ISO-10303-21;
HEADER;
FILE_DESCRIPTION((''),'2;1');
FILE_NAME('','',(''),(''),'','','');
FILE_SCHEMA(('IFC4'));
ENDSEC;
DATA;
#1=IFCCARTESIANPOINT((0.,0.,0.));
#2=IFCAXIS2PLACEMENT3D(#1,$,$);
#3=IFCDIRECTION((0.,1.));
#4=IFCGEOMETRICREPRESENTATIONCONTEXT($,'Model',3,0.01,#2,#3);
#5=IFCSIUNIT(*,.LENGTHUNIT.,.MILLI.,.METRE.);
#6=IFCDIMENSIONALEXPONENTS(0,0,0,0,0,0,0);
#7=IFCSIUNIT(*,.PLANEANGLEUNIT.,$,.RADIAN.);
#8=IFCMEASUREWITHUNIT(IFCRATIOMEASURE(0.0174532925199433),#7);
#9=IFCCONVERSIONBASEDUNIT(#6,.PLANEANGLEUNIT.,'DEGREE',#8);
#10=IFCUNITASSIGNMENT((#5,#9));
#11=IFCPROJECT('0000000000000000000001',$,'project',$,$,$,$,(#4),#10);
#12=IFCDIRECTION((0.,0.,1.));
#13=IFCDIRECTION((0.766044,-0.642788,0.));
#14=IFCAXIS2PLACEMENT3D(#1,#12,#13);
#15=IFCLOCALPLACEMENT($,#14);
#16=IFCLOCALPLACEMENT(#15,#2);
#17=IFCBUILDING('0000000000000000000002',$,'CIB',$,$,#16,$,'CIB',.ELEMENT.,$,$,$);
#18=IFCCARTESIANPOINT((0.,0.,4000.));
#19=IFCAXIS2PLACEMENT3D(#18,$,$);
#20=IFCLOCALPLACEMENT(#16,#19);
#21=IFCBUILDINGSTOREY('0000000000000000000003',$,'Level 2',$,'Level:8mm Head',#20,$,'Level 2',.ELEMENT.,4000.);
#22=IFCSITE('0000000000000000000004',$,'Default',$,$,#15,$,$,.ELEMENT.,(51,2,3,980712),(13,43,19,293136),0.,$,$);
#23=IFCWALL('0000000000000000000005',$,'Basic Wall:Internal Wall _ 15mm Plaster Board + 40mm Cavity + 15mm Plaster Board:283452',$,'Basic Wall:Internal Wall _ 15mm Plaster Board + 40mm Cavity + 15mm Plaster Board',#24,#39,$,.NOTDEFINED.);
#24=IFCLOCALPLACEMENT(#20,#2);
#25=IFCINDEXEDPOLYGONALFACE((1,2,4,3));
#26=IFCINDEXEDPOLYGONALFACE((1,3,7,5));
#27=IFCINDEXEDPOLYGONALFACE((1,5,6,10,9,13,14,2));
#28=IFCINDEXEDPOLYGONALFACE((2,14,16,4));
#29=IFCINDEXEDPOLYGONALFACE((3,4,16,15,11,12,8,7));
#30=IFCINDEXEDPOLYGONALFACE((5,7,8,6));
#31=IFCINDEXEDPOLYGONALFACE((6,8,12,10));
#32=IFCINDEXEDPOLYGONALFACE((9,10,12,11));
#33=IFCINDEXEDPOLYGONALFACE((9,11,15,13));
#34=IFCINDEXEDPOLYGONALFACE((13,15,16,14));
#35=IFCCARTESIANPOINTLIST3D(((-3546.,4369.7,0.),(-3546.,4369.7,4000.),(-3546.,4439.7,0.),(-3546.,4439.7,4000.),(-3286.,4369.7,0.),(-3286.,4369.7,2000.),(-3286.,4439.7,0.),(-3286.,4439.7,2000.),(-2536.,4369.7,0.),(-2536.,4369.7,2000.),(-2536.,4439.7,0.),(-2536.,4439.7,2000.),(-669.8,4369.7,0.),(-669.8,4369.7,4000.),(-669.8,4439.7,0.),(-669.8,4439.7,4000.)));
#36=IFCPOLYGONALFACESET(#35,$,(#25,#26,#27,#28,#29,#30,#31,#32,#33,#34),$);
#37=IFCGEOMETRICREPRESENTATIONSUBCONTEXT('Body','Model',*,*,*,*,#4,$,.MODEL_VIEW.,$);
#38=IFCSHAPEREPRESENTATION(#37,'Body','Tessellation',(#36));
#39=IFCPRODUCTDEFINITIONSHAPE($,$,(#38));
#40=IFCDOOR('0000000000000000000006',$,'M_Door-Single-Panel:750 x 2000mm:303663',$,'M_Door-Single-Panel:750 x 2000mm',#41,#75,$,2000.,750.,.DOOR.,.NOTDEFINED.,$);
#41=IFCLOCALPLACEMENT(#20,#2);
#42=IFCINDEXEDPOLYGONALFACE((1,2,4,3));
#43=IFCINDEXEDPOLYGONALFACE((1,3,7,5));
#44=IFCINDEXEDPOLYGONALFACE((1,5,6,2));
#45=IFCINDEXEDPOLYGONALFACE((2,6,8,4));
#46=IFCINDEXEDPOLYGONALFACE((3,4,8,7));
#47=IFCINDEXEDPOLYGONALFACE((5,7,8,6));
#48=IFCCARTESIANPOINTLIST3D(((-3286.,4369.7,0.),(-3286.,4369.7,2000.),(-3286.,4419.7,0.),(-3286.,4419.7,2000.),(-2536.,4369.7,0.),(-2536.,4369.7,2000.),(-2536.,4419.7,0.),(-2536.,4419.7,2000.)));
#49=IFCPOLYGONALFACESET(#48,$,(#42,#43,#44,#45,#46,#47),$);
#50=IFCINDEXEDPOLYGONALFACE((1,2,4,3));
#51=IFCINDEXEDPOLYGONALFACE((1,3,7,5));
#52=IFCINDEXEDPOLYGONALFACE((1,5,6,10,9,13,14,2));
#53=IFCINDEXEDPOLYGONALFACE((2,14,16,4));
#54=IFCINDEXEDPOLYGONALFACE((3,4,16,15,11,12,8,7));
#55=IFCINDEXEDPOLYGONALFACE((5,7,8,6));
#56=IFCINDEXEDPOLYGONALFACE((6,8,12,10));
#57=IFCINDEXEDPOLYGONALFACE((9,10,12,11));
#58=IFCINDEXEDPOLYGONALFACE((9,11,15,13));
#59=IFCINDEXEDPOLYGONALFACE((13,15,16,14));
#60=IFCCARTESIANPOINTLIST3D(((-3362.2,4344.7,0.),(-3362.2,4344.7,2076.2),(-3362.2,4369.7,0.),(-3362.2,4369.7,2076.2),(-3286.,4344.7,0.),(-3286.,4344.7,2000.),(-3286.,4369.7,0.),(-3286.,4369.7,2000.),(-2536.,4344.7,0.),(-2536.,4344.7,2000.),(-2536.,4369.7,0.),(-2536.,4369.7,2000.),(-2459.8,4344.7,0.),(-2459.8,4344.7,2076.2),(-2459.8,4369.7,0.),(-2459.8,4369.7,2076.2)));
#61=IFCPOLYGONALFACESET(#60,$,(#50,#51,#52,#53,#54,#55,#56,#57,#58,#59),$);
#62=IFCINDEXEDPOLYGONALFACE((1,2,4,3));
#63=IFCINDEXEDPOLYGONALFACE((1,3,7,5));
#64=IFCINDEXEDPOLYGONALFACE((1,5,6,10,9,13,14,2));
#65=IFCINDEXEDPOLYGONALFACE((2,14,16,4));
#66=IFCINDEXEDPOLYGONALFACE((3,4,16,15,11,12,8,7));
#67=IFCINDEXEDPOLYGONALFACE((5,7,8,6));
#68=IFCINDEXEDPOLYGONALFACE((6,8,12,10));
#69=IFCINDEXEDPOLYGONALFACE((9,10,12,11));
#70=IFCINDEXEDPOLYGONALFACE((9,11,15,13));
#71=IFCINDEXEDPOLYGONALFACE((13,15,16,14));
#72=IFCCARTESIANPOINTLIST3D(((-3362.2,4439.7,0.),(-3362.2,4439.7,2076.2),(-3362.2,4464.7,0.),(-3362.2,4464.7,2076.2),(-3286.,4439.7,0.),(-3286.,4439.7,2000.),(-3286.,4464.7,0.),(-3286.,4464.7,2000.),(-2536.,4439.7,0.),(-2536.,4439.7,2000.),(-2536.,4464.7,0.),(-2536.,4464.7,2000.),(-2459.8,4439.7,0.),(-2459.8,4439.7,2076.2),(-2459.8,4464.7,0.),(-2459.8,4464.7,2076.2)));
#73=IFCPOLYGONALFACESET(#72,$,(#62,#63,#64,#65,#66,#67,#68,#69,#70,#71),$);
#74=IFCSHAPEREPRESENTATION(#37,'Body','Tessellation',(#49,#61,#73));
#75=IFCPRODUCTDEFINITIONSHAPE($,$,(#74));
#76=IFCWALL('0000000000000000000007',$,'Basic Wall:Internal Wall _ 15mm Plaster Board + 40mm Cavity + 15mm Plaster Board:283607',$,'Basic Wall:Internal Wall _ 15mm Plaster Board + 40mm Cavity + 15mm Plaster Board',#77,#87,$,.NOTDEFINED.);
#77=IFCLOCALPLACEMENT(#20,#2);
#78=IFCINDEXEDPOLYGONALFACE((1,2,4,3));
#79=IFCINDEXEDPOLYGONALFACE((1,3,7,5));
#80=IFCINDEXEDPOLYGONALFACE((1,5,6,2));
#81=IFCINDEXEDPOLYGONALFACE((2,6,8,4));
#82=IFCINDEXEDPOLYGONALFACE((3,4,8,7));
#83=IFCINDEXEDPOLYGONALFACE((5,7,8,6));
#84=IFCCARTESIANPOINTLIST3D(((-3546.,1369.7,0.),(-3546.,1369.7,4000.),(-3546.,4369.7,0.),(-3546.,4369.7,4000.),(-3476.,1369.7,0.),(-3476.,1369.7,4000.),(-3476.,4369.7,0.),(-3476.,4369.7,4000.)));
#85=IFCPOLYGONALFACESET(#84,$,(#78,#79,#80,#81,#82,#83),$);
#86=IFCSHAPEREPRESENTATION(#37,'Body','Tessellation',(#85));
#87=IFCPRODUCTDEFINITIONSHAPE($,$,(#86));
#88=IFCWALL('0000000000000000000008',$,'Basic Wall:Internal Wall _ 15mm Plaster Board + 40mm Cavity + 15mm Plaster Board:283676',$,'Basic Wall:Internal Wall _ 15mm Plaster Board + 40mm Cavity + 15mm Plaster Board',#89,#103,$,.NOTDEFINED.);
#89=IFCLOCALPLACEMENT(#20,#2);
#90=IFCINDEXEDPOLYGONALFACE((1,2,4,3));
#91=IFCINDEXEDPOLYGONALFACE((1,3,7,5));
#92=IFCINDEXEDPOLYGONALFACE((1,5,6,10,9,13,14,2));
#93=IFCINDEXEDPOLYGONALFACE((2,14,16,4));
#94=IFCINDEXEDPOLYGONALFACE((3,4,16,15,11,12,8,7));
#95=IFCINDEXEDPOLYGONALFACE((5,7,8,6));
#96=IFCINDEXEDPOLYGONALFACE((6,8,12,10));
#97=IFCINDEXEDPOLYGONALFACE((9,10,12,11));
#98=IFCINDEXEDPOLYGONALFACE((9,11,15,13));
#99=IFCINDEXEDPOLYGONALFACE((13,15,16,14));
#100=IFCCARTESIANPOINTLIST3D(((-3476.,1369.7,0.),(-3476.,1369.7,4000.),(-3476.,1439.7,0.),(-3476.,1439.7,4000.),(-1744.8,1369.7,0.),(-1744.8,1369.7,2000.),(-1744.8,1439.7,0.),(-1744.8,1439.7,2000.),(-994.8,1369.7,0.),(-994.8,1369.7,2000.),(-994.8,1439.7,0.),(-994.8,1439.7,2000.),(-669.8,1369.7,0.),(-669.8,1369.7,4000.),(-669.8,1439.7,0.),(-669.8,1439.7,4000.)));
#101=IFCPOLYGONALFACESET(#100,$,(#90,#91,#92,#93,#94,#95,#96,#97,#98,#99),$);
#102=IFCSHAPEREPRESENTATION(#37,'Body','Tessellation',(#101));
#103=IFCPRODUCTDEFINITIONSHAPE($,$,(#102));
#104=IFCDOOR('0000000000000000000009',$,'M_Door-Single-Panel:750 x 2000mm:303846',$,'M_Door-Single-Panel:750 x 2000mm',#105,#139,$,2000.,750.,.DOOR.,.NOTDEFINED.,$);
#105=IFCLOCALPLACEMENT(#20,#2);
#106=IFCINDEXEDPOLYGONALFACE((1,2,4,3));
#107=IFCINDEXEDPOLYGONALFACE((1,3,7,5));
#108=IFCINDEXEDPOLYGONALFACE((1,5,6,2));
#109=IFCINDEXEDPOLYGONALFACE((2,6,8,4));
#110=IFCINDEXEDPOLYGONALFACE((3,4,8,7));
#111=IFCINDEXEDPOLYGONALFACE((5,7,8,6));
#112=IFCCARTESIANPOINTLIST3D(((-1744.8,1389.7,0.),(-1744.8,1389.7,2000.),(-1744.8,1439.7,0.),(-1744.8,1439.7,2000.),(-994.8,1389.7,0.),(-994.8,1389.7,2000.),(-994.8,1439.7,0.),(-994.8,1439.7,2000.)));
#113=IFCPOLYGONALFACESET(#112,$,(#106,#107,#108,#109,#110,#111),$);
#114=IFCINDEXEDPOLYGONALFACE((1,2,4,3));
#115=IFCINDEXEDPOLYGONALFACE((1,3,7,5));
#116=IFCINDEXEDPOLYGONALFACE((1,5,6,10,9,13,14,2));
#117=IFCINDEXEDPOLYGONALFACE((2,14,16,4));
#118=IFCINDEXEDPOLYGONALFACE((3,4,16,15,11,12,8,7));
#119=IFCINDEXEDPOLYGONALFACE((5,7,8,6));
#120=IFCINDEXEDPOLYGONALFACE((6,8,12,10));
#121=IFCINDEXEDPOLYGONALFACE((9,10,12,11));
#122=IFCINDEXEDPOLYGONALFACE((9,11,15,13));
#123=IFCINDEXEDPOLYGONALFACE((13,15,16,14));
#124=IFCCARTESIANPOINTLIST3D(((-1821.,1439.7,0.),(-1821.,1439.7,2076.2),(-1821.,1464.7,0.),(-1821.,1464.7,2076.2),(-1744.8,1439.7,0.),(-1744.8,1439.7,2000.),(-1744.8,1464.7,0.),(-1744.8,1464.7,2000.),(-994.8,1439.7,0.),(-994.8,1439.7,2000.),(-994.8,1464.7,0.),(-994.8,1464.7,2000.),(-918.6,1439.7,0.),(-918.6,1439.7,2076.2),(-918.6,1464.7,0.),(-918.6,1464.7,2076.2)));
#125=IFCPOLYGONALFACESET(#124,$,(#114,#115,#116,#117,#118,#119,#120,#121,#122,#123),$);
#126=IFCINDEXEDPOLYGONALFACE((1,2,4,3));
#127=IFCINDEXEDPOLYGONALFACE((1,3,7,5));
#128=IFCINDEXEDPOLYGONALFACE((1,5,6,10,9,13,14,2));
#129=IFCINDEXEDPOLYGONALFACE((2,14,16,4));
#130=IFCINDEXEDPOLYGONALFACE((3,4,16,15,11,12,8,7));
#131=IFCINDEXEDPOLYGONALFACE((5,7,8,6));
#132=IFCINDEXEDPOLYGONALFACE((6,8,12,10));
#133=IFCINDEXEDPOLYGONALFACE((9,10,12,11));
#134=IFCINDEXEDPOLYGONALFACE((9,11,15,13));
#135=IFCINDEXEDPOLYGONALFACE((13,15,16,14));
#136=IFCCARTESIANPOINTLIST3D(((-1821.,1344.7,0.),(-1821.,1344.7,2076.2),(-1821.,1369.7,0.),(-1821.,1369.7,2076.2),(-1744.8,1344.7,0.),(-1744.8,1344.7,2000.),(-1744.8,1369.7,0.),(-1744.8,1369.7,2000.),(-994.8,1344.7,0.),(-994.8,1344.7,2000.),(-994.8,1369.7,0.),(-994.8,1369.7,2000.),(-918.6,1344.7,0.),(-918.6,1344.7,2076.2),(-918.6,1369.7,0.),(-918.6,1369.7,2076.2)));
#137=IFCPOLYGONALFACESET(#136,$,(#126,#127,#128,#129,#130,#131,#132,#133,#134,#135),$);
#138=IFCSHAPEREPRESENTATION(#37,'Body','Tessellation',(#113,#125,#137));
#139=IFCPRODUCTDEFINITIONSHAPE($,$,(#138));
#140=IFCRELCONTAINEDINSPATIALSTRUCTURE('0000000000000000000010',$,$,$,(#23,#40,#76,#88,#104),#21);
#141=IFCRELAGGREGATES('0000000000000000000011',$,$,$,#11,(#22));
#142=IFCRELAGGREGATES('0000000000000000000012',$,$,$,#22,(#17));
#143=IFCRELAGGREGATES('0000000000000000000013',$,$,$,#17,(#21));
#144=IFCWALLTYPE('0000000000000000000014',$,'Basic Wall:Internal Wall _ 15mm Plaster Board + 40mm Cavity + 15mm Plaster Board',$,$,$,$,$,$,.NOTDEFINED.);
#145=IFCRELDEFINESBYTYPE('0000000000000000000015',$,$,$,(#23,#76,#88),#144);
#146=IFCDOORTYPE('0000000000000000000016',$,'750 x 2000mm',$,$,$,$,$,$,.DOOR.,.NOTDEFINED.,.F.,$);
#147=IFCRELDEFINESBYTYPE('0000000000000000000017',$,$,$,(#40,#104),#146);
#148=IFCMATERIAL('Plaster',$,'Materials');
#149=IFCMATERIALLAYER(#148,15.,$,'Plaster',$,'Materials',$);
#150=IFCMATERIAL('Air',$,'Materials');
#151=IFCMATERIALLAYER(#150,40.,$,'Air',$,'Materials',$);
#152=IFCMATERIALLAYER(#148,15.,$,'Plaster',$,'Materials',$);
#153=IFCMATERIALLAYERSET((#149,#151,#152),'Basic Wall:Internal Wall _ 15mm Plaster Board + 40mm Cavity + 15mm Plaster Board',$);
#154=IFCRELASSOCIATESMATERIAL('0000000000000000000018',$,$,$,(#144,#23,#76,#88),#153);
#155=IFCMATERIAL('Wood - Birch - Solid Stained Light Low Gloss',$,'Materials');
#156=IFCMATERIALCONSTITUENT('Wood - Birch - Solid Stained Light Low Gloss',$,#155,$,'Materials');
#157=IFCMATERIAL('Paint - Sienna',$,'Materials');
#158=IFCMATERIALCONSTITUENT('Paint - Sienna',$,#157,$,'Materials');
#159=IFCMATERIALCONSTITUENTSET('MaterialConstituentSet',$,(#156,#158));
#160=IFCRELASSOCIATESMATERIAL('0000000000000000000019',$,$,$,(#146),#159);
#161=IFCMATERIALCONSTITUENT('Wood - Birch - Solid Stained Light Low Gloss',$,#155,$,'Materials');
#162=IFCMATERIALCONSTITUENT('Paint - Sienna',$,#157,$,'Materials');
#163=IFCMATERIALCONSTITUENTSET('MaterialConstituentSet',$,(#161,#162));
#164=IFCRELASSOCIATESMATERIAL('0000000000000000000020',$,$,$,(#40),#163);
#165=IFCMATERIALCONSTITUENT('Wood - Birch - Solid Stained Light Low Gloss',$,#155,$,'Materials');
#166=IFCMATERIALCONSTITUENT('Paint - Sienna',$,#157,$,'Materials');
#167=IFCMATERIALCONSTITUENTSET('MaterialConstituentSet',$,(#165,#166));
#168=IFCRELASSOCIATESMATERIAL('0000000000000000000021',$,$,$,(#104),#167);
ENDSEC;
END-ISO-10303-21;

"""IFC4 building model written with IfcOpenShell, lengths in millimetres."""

from ifc_helpers import new_model, entity, si_unit, converted_unit, direction, frame, frame_2d, origin, origin_2d_with_axis, place, context, subcontext, project, spatial, polyline, rectangle, outline, extrude, source, transform, mapped, material, layer, layer_set, layer_usage, constituent, constituent_set, type_object, type_shapes, element, fill, save


model = new_model("IFC4")

# Units and contexts
model_context = context("Model", 3, precision=0.01, world=origin(), true_north=direction((0.0, 1.0)))
body_context = subcontext(model_context, "Body", "Model", "MODEL_VIEW")
ifc_project = project(units=[si_unit("LENGTHUNIT", "METRE", prefix="MILLI"), converted_unit("PLANEANGLEUNIT", "DEGREE", entity("IfcRatioMeasure", 0.0174532925199433), si_unit("PLANEANGLEUNIT", "RADIAN"), dimensions=[0, 0, 0, 0, 0, 0, 0])], contexts=[model_context])

# Site, building, storey
site_placement = place(None, frame((0.0, 0.0, 0.0), z_axis=(0.0, 0.0, 1.0), x_axis=(0.766044, -0.642788, 0.0)))
site = spatial("IfcSite", under=ifc_project, at=site_placement, Name="Default", CompositionType="ELEMENT", RefLatitude=(51, 2, 3, 980712), RefLongitude=(13, 43, 19, 293136), RefElevation=0.0)
building_placement = place(site_placement, origin())
building = spatial("IfcBuilding", under=site, at=building_placement, Name="CIB", LongName="CIB", CompositionType="ELEMENT")
storey_placement = place(building_placement, frame((0.0, 0.0, 4000.0)))
storey = spatial("IfcBuildingStorey", under=building, at=storey_placement, Name="Level 2", ObjectType="Level:8mm Head", LongName="Level 2", CompositionType="ELEMENT", Elevation=4000.0)

# Shared definitions
ifc_material_1 = material(Name="Plaster", Category="Materials")

# Wall, opening, door
ifc_layer_1 = layer(ifc_material_1, 15.0, Name="Plaster", Category="Materials")
ifc_material_2 = material(Name="Air", Category="Materials")
ifc_layer_2 = layer(ifc_material_2, 40.0, Name="Air", Category="Materials")
ifc_layer_3 = layer(ifc_material_1, 15.0, Name="Plaster", Category="Materials")
ifc_layer_set_1 = layer_set([ifc_layer_1, ifc_layer_2, ifc_layer_3], Name="Basic Wall:Internal Wall _ 15mm Plaster Board + 40mm Cavity + 15mm Plaster Board")
wall_type_1 = type_object("IfcWallType", Name="Basic Wall:Internal Wall _ 15mm Plaster Board + 40mm Cavity + 15mm Plaster Board", PredefinedType="NOTDEFINED", material=ifc_layer_set_1)
ifc_material_3 = material(Name="Wood - Birch - Solid Stained Light Low Gloss", Category="Materials")
ifc_material_4 = material(Name="Paint - Sienna", Category="Materials")
ifc_layer_usage_1 = layer_usage(ifc_layer_set_1, "AXIS2", "NEGATIVE", 35.0)
wall_1_placement = place(storey_placement, frame((-669.8, 4404.7, 0.0), z_axis=(0.0, 0.0, 1.0), x_axis=(-1.0, 0.0, 0.0)))
wall_1 = element("IfcWall", 1, at=wall_1_placement, inside=storey, type_object=wall_type_1, material=ifc_layer_usage_1, Name="Basic Wall:Internal Wall _ 15mm Plaster Board + 40mm Cavity + 15mm Plaster Board:283452", ObjectType="Basic Wall:Internal Wall _ 15mm Plaster Board + 40mm Cavity + 15mm Plaster Board", PredefinedType="NOTDEFINED", context=body_context, shape_type="SweptSolid", body=[
    extrude(rectangle(XDim=2876.2, YDim=70.0, at=frame_2d((1438.1, 0.0), x_axis=(-1.0, 0.0))), origin(), (0.0, 0.0, 1.0), 4000.0),
])
opening_1_placement = place(wall_1_placement, frame((1866.2, -35.0, 0.0)))
opening_1 = element("IfcOpeningElement", 2, at=opening_1_placement, cuts=wall_1, ObjectType="Opening", PredefinedType="OPENING", context=body_context, shape_type="SweptSolid", body=[
    extrude(rectangle(XDim=750.0, YDim=2000.0, at=frame_2d((1000.0, 375.0), x_axis=(0.0, 1.0))), frame((0.0, 0.0, 0.0), z_axis=(0.0, 1.0, 0.0), x_axis=(0.0, 0.0, 1.0)), (0.0, 0.0, 1.0), 70.0),
])
ifc_constituent_1 = constituent(ifc_material_3, Name="Wood - Birch - Solid Stained Light Low Gloss", Category="Materials")
ifc_constituent_2 = constituent(ifc_material_4, Name="Paint - Sienna", Category="Materials")
ifc_constituent_set_1 = constituent_set(constituents=[ifc_constituent_1, ifc_constituent_2], Name="MaterialConstituentSet")
ifc_constituent_3 = constituent(ifc_material_3, Name="Wood - Birch - Solid Stained Light Low Gloss", Category="Materials")
ifc_constituent_4 = constituent(ifc_material_4, Name="Paint - Sienna", Category="Materials")
ifc_constituent_set_2 = constituent_set(constituents=[ifc_constituent_3, ifc_constituent_4], Name="MaterialConstituentSet")
door_type_1 = type_object("IfcDoorType", Name="750 x 2000mm", OperationType="NOTDEFINED", ParameterTakesPrecedence=False, PredefinedType="DOOR", material=ifc_constituent_set_2)
shared_shape_1 = source(origin(), body_context, "Body", "SweptSolid", [
    extrude(rectangle(XDim=50.0, YDim=750.0, at=origin_2d_with_axis()), frame((375.0, 45.0, 0.0), z_axis=(0.0, 0.0, 1.0), x_axis=(0.0, 1.0, 0.0)), (0.0, 0.0, 1.0), 2000.0),
    extrude(outline(polyline([(-451.2, -1057.2), (451.2, -1057.2), (451.2, 1019.0), (375.0, 1019.0), (375.0, -981.0), (-375.0, -981.0), (-375.0, 1019.0), (-451.2, 1019.0), (-451.2, -1057.2)])), frame((375.0, 70.0, 1019.0), z_axis=(0.0, 1.0, 0.0), x_axis=(1.0, 0.0, 0.0)), (0.0, 0.0, 1.0), 25.0),
    extrude(outline(polyline([(-1057.2, -451.2), (1019.0, -451.2), (1019.0, -375.0), (-981.0, -375.0), (-981.0, 375.0), (1019.0, 375.0), (1019.0, 451.2), (-1057.2, 451.2), (-1057.2, -451.2)])), frame((375.0, -25.0, 1019.0), z_axis=(0.0, 1.0, 0.0), x_axis=(0.0, 0.0, -1.0)), (0.0, 0.0, 1.0), 25.0),
])
type_shapes(door_type_1, [shared_shape_1])
door_1_placement = place(opening_1_placement, origin())
door_1 = element("IfcDoor", 3, at=door_1_placement, inside=storey, type_object=door_type_1, material=ifc_constituent_set_1, Name="M_Door-Single-Panel:750 x 2000mm:303663", ObjectType="M_Door-Single-Panel:750 x 2000mm", OperationType="NOTDEFINED", OverallHeight=2000.0, OverallWidth=750.0, PredefinedType="DOOR", context=body_context, shape_type="MappedRepresentation", body=[
    mapped(shared_shape_1, transform((0.0, 0.0, 0.0), scale=1.0)),
])
fill(opening_1, door_1)

# Wall
ifc_layer_usage_2 = layer_usage(ifc_layer_set_1, "AXIS2", "NEGATIVE", 35.0)
wall_2_placement = place(storey_placement, frame((-3511.0, 4369.7, 0.0), z_axis=(0.0, 0.0, 1.0), x_axis=(0.0, -1.0, 0.0)))
element("IfcWall", 4, at=wall_2_placement, inside=storey, type_object=wall_type_1, material=ifc_layer_usage_2, Name="Basic Wall:Internal Wall _ 15mm Plaster Board + 40mm Cavity + 15mm Plaster Board:283607", ObjectType="Basic Wall:Internal Wall _ 15mm Plaster Board + 40mm Cavity + 15mm Plaster Board", PredefinedType="NOTDEFINED", context=body_context, shape_type="SweptSolid", body=[
    extrude(rectangle(XDim=3000.0, YDim=70.0, at=frame_2d((1500.0, 0.0), x_axis=(-1.0, 0.0))), origin(), (0.0, 0.0, 1.0), 4000.0),
])

# Wall, opening, door
ifc_layer_usage_3 = layer_usage(ifc_layer_set_1, "AXIS2", "NEGATIVE", 35.0)
wall_3_placement = place(storey_placement, frame((-3476.0, 1404.7, 0.0)))
wall_3 = element("IfcWall", 5, at=wall_3_placement, inside=storey, type_object=wall_type_1, material=ifc_layer_usage_3, Name="Basic Wall:Internal Wall _ 15mm Plaster Board + 40mm Cavity + 15mm Plaster Board:283676", ObjectType="Basic Wall:Internal Wall _ 15mm Plaster Board + 40mm Cavity + 15mm Plaster Board", PredefinedType="NOTDEFINED", context=body_context, shape_type="SweptSolid", body=[
    extrude(rectangle(XDim=2806.3, YDim=70.0, at=frame_2d((1403.1, 0.0), x_axis=(-1.0, 0.0))), origin(), (0.0, 0.0, 1.0), 4000.0),
])
opening_2_placement = place(wall_3_placement, frame((1731.3, -35.0, 0.0)))
opening_2 = element("IfcOpeningElement", 6, at=opening_2_placement, cuts=wall_3, ObjectType="Opening", PredefinedType="OPENING", context=body_context, shape_type="SweptSolid", body=[
    extrude(rectangle(XDim=750.0, YDim=2000.0, at=frame_2d((1000.0, 375.0), x_axis=(0.0, 1.0))), frame((0.0, 0.0, 0.0), z_axis=(0.0, 1.0, 0.0), x_axis=(0.0, 0.0, 1.0)), (0.0, 0.0, 1.0), 70.0),
])
ifc_constituent_5 = constituent(ifc_material_3, Name="Wood - Birch - Solid Stained Light Low Gloss", Category="Materials")
ifc_constituent_6 = constituent(ifc_material_4, Name="Paint - Sienna", Category="Materials")
ifc_constituent_set_3 = constituent_set(constituents=[ifc_constituent_5, ifc_constituent_6], Name="MaterialConstituentSet")
door_2_placement = place(opening_2_placement, origin())
door_2 = element("IfcDoor", 7, at=door_2_placement, inside=storey, type_object=door_type_1, material=ifc_constituent_set_3, Name="M_Door-Single-Panel:750 x 2000mm:303846", ObjectType="M_Door-Single-Panel:750 x 2000mm", OperationType="NOTDEFINED", OverallHeight=2000.0, OverallWidth=750.0, PredefinedType="DOOR", context=body_context, shape_type="MappedRepresentation", body=[
    mapped(shared_shape_1, transform((0.0, 0.0, 0.0), scale=1.0)),
])
fill(opening_2, door_2)

save(model, "model.ifc")
